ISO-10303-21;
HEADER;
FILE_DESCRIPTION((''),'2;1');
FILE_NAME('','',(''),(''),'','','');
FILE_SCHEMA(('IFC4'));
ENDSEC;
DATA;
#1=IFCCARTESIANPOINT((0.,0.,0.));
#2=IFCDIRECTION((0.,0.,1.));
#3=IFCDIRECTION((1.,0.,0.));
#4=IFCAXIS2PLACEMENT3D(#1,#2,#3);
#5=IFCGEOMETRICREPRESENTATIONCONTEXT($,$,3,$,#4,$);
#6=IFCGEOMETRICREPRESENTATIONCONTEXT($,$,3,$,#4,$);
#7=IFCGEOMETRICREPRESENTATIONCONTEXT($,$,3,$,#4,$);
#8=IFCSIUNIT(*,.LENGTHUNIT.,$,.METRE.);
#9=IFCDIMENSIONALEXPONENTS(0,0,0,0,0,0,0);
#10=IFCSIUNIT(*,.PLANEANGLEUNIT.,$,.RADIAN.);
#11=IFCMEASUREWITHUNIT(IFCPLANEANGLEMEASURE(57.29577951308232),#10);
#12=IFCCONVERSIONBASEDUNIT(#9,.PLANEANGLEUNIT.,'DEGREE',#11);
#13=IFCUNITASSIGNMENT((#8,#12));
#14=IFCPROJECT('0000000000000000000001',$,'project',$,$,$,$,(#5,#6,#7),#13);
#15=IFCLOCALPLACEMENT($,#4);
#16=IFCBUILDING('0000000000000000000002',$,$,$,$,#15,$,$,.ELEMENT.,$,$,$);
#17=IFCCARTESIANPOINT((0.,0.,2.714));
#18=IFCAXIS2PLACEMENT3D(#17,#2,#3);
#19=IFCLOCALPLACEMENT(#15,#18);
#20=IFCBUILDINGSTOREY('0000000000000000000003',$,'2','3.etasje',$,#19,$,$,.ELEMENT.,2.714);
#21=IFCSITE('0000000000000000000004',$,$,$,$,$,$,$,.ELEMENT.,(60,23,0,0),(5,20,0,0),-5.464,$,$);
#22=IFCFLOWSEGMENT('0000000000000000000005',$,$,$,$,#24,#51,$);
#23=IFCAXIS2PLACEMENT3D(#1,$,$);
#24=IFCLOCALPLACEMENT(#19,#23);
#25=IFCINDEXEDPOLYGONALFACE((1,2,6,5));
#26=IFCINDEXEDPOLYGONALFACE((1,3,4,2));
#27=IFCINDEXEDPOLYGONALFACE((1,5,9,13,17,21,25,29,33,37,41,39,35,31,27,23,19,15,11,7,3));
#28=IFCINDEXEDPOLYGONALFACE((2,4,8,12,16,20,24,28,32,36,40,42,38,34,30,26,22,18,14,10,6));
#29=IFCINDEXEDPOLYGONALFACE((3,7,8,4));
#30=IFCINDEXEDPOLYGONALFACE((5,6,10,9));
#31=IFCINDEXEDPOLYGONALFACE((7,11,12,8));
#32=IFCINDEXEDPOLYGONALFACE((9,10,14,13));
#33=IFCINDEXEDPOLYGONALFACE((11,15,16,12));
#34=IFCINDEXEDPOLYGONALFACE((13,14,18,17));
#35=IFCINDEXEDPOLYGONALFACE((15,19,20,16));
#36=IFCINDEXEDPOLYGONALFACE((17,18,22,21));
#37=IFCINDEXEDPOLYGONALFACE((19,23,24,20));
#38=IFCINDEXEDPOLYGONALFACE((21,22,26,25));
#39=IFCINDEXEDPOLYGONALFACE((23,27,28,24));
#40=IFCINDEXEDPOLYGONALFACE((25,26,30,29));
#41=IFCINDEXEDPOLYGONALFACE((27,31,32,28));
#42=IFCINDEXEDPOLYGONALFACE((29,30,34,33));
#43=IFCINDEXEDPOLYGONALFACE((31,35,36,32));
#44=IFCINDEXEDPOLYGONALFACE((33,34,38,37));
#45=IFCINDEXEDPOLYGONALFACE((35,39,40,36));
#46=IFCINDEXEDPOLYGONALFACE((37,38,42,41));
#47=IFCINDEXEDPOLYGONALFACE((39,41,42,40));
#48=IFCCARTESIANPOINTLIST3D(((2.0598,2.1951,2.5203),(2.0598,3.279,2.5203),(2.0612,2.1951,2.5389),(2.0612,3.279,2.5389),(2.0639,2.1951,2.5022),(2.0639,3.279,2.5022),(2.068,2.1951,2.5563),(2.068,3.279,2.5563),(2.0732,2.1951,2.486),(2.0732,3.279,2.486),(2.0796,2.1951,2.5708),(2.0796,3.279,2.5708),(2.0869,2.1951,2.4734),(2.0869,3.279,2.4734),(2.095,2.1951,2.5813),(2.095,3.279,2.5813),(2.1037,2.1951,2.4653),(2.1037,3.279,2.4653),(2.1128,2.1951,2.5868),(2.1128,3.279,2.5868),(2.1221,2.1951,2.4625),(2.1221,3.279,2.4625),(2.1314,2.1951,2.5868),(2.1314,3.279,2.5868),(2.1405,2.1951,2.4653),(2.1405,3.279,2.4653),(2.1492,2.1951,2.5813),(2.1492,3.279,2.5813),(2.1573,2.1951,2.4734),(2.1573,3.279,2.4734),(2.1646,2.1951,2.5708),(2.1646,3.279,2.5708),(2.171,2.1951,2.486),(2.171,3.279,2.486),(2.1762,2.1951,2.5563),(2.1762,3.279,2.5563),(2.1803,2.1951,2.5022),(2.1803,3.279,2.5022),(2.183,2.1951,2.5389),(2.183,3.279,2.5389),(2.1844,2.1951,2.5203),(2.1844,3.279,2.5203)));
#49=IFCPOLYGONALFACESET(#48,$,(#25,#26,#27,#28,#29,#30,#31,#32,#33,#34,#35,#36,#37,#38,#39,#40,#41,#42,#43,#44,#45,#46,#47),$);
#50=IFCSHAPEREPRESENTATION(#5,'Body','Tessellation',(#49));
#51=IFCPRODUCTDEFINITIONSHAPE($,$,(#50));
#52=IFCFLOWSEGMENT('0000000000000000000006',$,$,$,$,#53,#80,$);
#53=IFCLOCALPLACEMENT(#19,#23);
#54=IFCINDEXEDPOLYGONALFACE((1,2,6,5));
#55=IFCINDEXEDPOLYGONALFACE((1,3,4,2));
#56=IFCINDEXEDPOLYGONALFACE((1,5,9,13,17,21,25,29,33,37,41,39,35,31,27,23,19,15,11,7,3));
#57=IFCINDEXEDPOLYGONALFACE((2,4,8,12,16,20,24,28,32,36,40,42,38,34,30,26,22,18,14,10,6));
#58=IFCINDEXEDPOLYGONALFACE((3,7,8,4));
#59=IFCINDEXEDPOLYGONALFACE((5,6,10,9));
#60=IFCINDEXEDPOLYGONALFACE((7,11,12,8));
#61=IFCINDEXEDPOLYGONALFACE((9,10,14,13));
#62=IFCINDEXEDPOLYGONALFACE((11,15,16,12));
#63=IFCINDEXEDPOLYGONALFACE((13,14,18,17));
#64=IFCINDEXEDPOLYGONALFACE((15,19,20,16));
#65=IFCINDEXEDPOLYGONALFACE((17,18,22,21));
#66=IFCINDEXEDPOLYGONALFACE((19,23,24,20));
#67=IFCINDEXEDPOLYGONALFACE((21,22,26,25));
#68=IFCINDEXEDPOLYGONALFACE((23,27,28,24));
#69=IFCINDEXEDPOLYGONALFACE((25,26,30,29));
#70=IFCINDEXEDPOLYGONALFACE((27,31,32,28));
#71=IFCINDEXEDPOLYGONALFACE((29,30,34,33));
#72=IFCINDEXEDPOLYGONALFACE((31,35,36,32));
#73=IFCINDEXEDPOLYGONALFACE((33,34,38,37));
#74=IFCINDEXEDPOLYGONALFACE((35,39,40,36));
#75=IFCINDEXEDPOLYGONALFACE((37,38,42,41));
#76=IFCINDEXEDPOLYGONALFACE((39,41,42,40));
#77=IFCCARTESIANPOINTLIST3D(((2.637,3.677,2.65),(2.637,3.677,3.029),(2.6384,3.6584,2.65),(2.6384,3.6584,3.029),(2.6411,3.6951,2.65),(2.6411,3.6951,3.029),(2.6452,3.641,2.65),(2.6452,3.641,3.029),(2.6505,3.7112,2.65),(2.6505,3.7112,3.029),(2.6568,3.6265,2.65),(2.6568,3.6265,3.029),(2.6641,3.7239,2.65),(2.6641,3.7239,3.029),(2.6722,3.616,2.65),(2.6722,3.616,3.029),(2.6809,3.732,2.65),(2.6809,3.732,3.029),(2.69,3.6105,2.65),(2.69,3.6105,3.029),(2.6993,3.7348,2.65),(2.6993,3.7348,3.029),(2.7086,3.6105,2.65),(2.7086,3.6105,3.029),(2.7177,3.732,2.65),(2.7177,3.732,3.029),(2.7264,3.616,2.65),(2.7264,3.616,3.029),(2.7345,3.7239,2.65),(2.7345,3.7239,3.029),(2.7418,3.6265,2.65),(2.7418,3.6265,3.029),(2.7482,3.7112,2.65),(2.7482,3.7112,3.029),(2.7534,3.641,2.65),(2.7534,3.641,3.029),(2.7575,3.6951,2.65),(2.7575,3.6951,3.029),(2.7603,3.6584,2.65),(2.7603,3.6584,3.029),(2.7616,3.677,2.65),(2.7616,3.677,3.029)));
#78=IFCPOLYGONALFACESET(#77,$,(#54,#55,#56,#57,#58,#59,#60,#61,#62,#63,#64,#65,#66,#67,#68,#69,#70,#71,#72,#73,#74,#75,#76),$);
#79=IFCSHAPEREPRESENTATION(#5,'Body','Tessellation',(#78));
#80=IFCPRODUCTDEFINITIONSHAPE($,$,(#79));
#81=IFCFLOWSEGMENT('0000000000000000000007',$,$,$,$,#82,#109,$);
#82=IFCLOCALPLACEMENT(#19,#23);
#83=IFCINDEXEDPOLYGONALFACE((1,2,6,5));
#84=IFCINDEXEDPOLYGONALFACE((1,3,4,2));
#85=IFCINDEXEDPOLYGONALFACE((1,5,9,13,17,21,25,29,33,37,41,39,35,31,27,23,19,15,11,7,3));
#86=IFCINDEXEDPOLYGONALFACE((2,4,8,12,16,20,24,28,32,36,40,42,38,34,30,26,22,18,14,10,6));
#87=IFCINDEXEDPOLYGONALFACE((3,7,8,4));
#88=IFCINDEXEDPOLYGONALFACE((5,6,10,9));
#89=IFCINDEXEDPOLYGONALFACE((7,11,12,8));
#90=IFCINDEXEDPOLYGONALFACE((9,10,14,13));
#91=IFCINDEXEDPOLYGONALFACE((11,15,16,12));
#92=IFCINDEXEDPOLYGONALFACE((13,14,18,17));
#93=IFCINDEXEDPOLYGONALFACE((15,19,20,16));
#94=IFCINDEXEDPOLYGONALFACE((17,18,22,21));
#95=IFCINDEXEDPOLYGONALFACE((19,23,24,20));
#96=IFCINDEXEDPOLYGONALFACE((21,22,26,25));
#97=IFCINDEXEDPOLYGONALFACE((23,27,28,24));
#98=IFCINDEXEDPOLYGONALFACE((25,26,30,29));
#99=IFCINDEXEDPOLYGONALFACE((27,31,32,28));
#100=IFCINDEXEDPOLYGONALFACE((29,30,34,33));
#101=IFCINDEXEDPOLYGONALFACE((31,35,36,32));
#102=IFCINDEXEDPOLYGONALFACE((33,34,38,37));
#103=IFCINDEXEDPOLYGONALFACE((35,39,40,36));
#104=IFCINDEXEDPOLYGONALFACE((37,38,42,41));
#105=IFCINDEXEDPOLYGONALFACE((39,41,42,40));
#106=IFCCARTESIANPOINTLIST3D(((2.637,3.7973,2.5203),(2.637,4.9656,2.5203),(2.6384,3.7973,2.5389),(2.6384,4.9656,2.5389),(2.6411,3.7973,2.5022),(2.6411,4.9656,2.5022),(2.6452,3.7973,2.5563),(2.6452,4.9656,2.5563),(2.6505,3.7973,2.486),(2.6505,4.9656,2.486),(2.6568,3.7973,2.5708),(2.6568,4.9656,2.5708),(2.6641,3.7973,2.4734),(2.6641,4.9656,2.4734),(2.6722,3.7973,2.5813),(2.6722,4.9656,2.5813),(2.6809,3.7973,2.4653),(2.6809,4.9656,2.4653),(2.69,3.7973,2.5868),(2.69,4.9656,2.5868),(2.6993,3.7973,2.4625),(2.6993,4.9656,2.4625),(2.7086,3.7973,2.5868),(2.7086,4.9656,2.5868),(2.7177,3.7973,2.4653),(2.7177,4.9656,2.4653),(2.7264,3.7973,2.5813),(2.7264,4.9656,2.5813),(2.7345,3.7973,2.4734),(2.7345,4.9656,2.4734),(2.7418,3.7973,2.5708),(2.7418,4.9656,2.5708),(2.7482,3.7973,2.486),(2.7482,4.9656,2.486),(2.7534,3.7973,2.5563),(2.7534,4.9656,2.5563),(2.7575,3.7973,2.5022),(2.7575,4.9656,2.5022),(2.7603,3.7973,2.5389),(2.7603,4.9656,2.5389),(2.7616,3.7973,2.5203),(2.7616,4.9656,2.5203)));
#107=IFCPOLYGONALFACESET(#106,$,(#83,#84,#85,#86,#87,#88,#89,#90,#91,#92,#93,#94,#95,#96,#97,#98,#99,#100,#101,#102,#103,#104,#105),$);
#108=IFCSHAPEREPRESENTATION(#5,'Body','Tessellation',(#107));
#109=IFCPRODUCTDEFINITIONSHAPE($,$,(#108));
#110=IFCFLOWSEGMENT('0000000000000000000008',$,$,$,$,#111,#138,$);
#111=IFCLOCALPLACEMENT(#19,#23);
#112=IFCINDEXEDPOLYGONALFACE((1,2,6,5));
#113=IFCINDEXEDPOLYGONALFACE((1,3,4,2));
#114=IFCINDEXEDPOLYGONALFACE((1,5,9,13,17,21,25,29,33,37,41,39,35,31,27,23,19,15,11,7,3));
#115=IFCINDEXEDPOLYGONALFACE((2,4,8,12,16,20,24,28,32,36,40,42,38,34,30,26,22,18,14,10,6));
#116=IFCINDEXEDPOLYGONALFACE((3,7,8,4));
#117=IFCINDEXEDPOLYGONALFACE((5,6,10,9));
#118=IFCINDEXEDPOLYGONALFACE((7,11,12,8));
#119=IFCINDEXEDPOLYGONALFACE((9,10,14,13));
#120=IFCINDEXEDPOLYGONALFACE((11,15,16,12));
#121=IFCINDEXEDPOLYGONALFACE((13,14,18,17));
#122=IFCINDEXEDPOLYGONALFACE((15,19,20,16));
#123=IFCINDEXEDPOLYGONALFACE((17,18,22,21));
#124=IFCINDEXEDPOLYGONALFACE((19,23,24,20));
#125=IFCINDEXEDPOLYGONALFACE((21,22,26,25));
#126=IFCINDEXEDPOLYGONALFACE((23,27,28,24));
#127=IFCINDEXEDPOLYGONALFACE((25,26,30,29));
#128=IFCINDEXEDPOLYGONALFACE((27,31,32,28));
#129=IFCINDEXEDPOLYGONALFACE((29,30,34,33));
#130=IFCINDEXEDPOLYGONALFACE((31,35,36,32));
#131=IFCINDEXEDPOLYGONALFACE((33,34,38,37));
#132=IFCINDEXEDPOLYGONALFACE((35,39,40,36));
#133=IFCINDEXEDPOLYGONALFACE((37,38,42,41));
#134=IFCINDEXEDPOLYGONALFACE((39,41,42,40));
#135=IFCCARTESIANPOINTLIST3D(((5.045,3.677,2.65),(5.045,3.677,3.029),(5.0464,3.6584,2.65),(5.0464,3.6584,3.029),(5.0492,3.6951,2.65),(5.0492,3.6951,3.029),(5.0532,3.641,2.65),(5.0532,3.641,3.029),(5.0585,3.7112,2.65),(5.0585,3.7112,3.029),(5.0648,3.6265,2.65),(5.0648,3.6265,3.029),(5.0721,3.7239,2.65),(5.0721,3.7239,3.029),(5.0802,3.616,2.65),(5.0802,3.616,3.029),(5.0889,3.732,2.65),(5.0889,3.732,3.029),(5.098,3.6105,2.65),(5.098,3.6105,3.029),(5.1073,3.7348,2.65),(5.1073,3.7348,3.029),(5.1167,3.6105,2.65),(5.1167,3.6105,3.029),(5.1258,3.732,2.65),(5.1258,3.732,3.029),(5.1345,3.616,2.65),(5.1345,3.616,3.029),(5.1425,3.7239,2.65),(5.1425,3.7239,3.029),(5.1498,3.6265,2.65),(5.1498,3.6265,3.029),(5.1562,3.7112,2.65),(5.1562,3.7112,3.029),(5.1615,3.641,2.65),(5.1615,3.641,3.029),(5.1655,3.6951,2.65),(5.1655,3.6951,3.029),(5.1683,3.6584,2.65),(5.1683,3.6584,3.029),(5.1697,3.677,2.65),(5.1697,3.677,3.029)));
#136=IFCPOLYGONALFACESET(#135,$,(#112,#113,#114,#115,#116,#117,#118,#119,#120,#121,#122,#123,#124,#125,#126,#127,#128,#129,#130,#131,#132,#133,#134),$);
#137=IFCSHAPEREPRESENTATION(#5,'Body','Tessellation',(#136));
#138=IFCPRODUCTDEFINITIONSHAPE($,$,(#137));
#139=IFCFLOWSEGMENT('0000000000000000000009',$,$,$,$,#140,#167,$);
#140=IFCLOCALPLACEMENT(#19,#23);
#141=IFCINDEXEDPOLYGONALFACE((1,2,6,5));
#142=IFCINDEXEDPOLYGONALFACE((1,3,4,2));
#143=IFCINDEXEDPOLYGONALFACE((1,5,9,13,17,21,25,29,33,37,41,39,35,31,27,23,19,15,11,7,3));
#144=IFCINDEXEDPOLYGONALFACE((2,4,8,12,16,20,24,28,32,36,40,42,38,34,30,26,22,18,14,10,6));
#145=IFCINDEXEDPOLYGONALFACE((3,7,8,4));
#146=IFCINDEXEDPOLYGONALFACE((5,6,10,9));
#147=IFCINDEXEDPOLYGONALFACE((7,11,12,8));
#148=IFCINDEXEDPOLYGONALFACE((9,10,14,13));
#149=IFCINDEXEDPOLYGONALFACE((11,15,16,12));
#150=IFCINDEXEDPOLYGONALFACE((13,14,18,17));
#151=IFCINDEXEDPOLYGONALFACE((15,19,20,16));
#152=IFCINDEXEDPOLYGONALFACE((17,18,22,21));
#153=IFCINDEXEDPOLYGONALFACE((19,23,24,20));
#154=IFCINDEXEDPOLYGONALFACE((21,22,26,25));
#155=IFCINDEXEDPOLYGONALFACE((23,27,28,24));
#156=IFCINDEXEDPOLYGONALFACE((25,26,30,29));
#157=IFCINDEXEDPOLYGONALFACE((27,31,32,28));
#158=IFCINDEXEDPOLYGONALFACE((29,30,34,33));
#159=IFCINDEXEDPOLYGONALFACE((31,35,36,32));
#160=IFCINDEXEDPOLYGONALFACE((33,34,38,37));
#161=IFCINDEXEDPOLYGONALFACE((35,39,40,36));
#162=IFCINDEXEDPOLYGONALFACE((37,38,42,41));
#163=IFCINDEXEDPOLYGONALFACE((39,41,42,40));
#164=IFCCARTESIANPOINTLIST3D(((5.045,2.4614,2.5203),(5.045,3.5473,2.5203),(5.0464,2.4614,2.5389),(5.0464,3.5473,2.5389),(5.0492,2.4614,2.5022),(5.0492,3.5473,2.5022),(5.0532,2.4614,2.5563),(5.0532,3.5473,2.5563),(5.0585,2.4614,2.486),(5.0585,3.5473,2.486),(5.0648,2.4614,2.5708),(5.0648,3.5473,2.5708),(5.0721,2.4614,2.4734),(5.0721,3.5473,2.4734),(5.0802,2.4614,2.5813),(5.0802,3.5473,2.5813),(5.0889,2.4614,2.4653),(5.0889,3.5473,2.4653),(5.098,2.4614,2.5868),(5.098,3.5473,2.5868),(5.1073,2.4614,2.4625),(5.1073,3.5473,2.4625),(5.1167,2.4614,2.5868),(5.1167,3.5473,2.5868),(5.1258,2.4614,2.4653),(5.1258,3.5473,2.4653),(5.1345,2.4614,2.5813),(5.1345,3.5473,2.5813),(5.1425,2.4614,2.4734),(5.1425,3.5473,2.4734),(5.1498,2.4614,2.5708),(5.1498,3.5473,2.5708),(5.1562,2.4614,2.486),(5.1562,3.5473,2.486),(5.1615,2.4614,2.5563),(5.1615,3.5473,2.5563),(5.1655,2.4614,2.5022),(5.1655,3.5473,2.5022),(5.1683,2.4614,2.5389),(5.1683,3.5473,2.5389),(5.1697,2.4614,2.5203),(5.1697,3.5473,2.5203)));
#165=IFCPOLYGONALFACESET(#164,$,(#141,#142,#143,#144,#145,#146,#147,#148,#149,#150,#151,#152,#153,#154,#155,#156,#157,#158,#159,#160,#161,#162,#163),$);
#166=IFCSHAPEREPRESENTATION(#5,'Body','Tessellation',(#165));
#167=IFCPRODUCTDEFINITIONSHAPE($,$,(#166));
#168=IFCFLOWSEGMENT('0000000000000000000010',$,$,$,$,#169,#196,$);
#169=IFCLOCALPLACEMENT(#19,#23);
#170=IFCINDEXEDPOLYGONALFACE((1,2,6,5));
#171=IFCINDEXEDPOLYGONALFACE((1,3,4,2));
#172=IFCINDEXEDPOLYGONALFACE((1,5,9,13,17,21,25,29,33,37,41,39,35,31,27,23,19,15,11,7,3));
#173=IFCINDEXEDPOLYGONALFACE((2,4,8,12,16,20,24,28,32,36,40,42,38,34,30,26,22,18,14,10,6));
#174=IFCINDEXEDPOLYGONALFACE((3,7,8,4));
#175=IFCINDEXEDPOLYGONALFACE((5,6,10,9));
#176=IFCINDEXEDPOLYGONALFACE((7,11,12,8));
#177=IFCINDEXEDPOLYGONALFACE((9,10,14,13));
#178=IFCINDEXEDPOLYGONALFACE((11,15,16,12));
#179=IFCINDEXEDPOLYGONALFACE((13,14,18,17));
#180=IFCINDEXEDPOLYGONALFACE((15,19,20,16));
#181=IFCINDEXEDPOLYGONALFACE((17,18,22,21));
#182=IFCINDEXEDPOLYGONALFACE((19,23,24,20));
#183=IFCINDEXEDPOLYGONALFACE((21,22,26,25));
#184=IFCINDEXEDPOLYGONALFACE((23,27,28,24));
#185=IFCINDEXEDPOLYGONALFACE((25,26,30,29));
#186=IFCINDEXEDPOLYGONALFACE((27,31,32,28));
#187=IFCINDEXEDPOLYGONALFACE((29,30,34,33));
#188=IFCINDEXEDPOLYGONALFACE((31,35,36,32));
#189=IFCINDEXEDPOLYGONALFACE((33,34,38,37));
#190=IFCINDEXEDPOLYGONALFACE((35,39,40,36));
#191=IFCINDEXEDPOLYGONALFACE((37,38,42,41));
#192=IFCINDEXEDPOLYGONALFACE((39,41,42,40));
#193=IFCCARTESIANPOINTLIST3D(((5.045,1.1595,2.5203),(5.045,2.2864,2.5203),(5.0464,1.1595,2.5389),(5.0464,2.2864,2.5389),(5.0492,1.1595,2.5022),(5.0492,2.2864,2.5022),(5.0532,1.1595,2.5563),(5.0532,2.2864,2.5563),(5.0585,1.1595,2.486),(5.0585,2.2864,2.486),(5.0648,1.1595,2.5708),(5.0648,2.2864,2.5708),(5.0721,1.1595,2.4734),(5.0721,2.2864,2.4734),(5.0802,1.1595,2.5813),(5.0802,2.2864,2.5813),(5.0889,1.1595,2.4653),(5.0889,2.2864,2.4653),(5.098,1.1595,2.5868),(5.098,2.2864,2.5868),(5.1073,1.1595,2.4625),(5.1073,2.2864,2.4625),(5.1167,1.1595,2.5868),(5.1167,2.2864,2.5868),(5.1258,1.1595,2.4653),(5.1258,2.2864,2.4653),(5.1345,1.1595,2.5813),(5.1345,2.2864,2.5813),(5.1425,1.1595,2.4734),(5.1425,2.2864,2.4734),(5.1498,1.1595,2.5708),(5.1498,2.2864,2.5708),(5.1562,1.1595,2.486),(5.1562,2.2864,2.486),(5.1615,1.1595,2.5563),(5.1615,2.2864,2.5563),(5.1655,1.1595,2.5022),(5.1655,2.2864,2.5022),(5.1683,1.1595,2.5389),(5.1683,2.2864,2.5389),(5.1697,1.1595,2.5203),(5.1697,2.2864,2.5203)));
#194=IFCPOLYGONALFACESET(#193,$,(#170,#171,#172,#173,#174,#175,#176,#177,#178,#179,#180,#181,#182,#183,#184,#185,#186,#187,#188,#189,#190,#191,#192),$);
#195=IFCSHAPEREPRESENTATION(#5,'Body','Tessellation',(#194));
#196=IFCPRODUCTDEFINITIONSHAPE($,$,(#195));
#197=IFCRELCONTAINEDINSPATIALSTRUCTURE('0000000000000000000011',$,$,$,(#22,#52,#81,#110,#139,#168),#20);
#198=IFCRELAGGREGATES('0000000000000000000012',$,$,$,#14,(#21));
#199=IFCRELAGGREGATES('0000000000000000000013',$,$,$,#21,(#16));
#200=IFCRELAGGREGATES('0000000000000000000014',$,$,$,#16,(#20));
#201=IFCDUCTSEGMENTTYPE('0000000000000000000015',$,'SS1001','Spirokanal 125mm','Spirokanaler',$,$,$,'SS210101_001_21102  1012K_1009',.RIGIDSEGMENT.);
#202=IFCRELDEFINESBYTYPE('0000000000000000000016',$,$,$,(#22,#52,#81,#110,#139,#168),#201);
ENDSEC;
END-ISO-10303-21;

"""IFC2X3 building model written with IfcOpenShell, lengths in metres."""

from ifc_helpers import new_model, entity, si_unit, converted_unit, frame, origin_with_axes, origin_2d_with_axis, place, context, project, spatial, circle, extrude, type_object, element, save


model = new_model("IFC2X3")

# Units and contexts
context_of_model_1 = context(None, 3, world=origin_with_axes())
context_of_model_2 = context(None, 3, world=origin_with_axes())
context_of_model_3 = context(None, 3, world=origin_with_axes())
ifc_project = project(units=[si_unit("LENGTHUNIT", "METRE"), converted_unit("PLANEANGLEUNIT", "DEGREE", entity("IfcPlaneAngleMeasure", 57.29577951308232), si_unit("PLANEANGLEUNIT", "RADIAN"), dimensions=[0, 0, 0, 0, 0, 0, 0])], contexts=[context_of_model_1, context_of_model_2, context_of_model_3])

# Site, building, storey
site = spatial("IfcSite", under=ifc_project, CompositionType="ELEMENT", RefLatitude=(60, 23, 0, 0), RefLongitude=(5, 20, 0, 0), RefElevation=-5.464)
building_placement = place(None, origin_with_axes())
building = spatial("IfcBuilding", under=site, at=building_placement, CompositionType="ELEMENT")
storey_placement = place(building_placement, frame((0.0, 0.0, 2.714), z_axis=(0.0, 0.0, 1.0), x_axis=(1.0, 0.0, 0.0)))
storey = spatial("IfcBuildingStorey", under=building, at=storey_placement, Name="2", Description="3.etasje", CompositionType="ELEMENT", Elevation=2.714)

# Flow segments
duct_segment_type_1 = type_object("IfcDuctSegmentType", Name="SS1001", Description="Spirokanal 125mm", ApplicableOccurrence="Spirokanaler", ElementType="SS210101_001_21102  1012K_1009", PredefinedType="RIGIDSEGMENT")
flow_segment_1_placement = place(storey_placement, frame((2.1221, 3.279, 2.525), z_axis=(0.0, -1.0, 0.0), x_axis=(0.0, 0.0, -1.0)))
element("IfcFlowSegment", 1, at=flow_segment_1_placement, inside=storey, type_object=duct_segment_type_1, context=context_of_model_1, shape_type="SweptSolid", body=[
    extrude(circle(Radius=0.0625, at=origin_2d_with_axis()), origin_with_axes(), (0.0, 0.0, 1.0), 1.0839),
])
flow_segment_2_placement = place(storey_placement, frame((2.6993, 3.6723, 3.029), z_axis=(0.0, 0.0, -1.0), x_axis=(0.0, 1.0, 0.0)))
element("IfcFlowSegment", 2, at=flow_segment_2_placement, inside=storey, type_object=duct_segment_type_1, context=context_of_model_1, shape_type="SweptSolid", body=[
    extrude(circle(Radius=0.0625, at=origin_2d_with_axis()), origin_with_axes(), (0.0, 0.0, 1.0), 0.379),
])
flow_segment_3_placement = place(storey_placement, frame((2.6993, 3.7973, 2.525), z_axis=(0.0, 1.0, 0.0), x_axis=(0.0, 0.0, -1.0)))
element("IfcFlowSegment", 3, at=flow_segment_3_placement, inside=storey, type_object=duct_segment_type_1, context=context_of_model_1, shape_type="SweptSolid", body=[
    extrude(circle(Radius=0.0625, at=origin_2d_with_axis()), origin_with_axes(), (0.0, 0.0, 1.0), 1.1683),
])
flow_segment_4_placement = place(storey_placement, frame((5.1073, 3.6723, 3.029), z_axis=(0.0, 0.0, -1.0), x_axis=(0.0, 1.0, 0.0)))
element("IfcFlowSegment", 4, at=flow_segment_4_placement, inside=storey, type_object=duct_segment_type_1, context=context_of_model_1, shape_type="SweptSolid", body=[
    extrude(circle(Radius=0.0625, at=origin_2d_with_axis()), origin_with_axes(), (0.0, 0.0, 1.0), 0.379),
])
flow_segment_5_placement = place(storey_placement, frame((5.1073, 3.5473, 2.525), z_axis=(0.0, -1.0, 0.0), x_axis=(0.0, 0.0, -1.0)))
element("IfcFlowSegment", 5, at=flow_segment_5_placement, inside=storey, type_object=duct_segment_type_1, context=context_of_model_1, shape_type="SweptSolid", body=[
    extrude(circle(Radius=0.0625, at=origin_2d_with_axis()), origin_with_axes(), (0.0, 0.0, 1.0), 1.0859),
])
flow_segment_6_placement = place(storey_placement, frame((5.1073, 2.2864, 2.525), z_axis=(0.0, -1.0, 0.0), x_axis=(0.0, 0.0, -1.0)))
element("IfcFlowSegment", 6, at=flow_segment_6_placement, inside=storey, type_object=duct_segment_type_1, context=context_of_model_1, shape_type="SweptSolid", body=[
    extrude(circle(Radius=0.0625, at=origin_2d_with_axis()), origin_with_axes(), (0.0, 0.0, 1.0), 1.1269),
])

save(model, "model.ifc")
